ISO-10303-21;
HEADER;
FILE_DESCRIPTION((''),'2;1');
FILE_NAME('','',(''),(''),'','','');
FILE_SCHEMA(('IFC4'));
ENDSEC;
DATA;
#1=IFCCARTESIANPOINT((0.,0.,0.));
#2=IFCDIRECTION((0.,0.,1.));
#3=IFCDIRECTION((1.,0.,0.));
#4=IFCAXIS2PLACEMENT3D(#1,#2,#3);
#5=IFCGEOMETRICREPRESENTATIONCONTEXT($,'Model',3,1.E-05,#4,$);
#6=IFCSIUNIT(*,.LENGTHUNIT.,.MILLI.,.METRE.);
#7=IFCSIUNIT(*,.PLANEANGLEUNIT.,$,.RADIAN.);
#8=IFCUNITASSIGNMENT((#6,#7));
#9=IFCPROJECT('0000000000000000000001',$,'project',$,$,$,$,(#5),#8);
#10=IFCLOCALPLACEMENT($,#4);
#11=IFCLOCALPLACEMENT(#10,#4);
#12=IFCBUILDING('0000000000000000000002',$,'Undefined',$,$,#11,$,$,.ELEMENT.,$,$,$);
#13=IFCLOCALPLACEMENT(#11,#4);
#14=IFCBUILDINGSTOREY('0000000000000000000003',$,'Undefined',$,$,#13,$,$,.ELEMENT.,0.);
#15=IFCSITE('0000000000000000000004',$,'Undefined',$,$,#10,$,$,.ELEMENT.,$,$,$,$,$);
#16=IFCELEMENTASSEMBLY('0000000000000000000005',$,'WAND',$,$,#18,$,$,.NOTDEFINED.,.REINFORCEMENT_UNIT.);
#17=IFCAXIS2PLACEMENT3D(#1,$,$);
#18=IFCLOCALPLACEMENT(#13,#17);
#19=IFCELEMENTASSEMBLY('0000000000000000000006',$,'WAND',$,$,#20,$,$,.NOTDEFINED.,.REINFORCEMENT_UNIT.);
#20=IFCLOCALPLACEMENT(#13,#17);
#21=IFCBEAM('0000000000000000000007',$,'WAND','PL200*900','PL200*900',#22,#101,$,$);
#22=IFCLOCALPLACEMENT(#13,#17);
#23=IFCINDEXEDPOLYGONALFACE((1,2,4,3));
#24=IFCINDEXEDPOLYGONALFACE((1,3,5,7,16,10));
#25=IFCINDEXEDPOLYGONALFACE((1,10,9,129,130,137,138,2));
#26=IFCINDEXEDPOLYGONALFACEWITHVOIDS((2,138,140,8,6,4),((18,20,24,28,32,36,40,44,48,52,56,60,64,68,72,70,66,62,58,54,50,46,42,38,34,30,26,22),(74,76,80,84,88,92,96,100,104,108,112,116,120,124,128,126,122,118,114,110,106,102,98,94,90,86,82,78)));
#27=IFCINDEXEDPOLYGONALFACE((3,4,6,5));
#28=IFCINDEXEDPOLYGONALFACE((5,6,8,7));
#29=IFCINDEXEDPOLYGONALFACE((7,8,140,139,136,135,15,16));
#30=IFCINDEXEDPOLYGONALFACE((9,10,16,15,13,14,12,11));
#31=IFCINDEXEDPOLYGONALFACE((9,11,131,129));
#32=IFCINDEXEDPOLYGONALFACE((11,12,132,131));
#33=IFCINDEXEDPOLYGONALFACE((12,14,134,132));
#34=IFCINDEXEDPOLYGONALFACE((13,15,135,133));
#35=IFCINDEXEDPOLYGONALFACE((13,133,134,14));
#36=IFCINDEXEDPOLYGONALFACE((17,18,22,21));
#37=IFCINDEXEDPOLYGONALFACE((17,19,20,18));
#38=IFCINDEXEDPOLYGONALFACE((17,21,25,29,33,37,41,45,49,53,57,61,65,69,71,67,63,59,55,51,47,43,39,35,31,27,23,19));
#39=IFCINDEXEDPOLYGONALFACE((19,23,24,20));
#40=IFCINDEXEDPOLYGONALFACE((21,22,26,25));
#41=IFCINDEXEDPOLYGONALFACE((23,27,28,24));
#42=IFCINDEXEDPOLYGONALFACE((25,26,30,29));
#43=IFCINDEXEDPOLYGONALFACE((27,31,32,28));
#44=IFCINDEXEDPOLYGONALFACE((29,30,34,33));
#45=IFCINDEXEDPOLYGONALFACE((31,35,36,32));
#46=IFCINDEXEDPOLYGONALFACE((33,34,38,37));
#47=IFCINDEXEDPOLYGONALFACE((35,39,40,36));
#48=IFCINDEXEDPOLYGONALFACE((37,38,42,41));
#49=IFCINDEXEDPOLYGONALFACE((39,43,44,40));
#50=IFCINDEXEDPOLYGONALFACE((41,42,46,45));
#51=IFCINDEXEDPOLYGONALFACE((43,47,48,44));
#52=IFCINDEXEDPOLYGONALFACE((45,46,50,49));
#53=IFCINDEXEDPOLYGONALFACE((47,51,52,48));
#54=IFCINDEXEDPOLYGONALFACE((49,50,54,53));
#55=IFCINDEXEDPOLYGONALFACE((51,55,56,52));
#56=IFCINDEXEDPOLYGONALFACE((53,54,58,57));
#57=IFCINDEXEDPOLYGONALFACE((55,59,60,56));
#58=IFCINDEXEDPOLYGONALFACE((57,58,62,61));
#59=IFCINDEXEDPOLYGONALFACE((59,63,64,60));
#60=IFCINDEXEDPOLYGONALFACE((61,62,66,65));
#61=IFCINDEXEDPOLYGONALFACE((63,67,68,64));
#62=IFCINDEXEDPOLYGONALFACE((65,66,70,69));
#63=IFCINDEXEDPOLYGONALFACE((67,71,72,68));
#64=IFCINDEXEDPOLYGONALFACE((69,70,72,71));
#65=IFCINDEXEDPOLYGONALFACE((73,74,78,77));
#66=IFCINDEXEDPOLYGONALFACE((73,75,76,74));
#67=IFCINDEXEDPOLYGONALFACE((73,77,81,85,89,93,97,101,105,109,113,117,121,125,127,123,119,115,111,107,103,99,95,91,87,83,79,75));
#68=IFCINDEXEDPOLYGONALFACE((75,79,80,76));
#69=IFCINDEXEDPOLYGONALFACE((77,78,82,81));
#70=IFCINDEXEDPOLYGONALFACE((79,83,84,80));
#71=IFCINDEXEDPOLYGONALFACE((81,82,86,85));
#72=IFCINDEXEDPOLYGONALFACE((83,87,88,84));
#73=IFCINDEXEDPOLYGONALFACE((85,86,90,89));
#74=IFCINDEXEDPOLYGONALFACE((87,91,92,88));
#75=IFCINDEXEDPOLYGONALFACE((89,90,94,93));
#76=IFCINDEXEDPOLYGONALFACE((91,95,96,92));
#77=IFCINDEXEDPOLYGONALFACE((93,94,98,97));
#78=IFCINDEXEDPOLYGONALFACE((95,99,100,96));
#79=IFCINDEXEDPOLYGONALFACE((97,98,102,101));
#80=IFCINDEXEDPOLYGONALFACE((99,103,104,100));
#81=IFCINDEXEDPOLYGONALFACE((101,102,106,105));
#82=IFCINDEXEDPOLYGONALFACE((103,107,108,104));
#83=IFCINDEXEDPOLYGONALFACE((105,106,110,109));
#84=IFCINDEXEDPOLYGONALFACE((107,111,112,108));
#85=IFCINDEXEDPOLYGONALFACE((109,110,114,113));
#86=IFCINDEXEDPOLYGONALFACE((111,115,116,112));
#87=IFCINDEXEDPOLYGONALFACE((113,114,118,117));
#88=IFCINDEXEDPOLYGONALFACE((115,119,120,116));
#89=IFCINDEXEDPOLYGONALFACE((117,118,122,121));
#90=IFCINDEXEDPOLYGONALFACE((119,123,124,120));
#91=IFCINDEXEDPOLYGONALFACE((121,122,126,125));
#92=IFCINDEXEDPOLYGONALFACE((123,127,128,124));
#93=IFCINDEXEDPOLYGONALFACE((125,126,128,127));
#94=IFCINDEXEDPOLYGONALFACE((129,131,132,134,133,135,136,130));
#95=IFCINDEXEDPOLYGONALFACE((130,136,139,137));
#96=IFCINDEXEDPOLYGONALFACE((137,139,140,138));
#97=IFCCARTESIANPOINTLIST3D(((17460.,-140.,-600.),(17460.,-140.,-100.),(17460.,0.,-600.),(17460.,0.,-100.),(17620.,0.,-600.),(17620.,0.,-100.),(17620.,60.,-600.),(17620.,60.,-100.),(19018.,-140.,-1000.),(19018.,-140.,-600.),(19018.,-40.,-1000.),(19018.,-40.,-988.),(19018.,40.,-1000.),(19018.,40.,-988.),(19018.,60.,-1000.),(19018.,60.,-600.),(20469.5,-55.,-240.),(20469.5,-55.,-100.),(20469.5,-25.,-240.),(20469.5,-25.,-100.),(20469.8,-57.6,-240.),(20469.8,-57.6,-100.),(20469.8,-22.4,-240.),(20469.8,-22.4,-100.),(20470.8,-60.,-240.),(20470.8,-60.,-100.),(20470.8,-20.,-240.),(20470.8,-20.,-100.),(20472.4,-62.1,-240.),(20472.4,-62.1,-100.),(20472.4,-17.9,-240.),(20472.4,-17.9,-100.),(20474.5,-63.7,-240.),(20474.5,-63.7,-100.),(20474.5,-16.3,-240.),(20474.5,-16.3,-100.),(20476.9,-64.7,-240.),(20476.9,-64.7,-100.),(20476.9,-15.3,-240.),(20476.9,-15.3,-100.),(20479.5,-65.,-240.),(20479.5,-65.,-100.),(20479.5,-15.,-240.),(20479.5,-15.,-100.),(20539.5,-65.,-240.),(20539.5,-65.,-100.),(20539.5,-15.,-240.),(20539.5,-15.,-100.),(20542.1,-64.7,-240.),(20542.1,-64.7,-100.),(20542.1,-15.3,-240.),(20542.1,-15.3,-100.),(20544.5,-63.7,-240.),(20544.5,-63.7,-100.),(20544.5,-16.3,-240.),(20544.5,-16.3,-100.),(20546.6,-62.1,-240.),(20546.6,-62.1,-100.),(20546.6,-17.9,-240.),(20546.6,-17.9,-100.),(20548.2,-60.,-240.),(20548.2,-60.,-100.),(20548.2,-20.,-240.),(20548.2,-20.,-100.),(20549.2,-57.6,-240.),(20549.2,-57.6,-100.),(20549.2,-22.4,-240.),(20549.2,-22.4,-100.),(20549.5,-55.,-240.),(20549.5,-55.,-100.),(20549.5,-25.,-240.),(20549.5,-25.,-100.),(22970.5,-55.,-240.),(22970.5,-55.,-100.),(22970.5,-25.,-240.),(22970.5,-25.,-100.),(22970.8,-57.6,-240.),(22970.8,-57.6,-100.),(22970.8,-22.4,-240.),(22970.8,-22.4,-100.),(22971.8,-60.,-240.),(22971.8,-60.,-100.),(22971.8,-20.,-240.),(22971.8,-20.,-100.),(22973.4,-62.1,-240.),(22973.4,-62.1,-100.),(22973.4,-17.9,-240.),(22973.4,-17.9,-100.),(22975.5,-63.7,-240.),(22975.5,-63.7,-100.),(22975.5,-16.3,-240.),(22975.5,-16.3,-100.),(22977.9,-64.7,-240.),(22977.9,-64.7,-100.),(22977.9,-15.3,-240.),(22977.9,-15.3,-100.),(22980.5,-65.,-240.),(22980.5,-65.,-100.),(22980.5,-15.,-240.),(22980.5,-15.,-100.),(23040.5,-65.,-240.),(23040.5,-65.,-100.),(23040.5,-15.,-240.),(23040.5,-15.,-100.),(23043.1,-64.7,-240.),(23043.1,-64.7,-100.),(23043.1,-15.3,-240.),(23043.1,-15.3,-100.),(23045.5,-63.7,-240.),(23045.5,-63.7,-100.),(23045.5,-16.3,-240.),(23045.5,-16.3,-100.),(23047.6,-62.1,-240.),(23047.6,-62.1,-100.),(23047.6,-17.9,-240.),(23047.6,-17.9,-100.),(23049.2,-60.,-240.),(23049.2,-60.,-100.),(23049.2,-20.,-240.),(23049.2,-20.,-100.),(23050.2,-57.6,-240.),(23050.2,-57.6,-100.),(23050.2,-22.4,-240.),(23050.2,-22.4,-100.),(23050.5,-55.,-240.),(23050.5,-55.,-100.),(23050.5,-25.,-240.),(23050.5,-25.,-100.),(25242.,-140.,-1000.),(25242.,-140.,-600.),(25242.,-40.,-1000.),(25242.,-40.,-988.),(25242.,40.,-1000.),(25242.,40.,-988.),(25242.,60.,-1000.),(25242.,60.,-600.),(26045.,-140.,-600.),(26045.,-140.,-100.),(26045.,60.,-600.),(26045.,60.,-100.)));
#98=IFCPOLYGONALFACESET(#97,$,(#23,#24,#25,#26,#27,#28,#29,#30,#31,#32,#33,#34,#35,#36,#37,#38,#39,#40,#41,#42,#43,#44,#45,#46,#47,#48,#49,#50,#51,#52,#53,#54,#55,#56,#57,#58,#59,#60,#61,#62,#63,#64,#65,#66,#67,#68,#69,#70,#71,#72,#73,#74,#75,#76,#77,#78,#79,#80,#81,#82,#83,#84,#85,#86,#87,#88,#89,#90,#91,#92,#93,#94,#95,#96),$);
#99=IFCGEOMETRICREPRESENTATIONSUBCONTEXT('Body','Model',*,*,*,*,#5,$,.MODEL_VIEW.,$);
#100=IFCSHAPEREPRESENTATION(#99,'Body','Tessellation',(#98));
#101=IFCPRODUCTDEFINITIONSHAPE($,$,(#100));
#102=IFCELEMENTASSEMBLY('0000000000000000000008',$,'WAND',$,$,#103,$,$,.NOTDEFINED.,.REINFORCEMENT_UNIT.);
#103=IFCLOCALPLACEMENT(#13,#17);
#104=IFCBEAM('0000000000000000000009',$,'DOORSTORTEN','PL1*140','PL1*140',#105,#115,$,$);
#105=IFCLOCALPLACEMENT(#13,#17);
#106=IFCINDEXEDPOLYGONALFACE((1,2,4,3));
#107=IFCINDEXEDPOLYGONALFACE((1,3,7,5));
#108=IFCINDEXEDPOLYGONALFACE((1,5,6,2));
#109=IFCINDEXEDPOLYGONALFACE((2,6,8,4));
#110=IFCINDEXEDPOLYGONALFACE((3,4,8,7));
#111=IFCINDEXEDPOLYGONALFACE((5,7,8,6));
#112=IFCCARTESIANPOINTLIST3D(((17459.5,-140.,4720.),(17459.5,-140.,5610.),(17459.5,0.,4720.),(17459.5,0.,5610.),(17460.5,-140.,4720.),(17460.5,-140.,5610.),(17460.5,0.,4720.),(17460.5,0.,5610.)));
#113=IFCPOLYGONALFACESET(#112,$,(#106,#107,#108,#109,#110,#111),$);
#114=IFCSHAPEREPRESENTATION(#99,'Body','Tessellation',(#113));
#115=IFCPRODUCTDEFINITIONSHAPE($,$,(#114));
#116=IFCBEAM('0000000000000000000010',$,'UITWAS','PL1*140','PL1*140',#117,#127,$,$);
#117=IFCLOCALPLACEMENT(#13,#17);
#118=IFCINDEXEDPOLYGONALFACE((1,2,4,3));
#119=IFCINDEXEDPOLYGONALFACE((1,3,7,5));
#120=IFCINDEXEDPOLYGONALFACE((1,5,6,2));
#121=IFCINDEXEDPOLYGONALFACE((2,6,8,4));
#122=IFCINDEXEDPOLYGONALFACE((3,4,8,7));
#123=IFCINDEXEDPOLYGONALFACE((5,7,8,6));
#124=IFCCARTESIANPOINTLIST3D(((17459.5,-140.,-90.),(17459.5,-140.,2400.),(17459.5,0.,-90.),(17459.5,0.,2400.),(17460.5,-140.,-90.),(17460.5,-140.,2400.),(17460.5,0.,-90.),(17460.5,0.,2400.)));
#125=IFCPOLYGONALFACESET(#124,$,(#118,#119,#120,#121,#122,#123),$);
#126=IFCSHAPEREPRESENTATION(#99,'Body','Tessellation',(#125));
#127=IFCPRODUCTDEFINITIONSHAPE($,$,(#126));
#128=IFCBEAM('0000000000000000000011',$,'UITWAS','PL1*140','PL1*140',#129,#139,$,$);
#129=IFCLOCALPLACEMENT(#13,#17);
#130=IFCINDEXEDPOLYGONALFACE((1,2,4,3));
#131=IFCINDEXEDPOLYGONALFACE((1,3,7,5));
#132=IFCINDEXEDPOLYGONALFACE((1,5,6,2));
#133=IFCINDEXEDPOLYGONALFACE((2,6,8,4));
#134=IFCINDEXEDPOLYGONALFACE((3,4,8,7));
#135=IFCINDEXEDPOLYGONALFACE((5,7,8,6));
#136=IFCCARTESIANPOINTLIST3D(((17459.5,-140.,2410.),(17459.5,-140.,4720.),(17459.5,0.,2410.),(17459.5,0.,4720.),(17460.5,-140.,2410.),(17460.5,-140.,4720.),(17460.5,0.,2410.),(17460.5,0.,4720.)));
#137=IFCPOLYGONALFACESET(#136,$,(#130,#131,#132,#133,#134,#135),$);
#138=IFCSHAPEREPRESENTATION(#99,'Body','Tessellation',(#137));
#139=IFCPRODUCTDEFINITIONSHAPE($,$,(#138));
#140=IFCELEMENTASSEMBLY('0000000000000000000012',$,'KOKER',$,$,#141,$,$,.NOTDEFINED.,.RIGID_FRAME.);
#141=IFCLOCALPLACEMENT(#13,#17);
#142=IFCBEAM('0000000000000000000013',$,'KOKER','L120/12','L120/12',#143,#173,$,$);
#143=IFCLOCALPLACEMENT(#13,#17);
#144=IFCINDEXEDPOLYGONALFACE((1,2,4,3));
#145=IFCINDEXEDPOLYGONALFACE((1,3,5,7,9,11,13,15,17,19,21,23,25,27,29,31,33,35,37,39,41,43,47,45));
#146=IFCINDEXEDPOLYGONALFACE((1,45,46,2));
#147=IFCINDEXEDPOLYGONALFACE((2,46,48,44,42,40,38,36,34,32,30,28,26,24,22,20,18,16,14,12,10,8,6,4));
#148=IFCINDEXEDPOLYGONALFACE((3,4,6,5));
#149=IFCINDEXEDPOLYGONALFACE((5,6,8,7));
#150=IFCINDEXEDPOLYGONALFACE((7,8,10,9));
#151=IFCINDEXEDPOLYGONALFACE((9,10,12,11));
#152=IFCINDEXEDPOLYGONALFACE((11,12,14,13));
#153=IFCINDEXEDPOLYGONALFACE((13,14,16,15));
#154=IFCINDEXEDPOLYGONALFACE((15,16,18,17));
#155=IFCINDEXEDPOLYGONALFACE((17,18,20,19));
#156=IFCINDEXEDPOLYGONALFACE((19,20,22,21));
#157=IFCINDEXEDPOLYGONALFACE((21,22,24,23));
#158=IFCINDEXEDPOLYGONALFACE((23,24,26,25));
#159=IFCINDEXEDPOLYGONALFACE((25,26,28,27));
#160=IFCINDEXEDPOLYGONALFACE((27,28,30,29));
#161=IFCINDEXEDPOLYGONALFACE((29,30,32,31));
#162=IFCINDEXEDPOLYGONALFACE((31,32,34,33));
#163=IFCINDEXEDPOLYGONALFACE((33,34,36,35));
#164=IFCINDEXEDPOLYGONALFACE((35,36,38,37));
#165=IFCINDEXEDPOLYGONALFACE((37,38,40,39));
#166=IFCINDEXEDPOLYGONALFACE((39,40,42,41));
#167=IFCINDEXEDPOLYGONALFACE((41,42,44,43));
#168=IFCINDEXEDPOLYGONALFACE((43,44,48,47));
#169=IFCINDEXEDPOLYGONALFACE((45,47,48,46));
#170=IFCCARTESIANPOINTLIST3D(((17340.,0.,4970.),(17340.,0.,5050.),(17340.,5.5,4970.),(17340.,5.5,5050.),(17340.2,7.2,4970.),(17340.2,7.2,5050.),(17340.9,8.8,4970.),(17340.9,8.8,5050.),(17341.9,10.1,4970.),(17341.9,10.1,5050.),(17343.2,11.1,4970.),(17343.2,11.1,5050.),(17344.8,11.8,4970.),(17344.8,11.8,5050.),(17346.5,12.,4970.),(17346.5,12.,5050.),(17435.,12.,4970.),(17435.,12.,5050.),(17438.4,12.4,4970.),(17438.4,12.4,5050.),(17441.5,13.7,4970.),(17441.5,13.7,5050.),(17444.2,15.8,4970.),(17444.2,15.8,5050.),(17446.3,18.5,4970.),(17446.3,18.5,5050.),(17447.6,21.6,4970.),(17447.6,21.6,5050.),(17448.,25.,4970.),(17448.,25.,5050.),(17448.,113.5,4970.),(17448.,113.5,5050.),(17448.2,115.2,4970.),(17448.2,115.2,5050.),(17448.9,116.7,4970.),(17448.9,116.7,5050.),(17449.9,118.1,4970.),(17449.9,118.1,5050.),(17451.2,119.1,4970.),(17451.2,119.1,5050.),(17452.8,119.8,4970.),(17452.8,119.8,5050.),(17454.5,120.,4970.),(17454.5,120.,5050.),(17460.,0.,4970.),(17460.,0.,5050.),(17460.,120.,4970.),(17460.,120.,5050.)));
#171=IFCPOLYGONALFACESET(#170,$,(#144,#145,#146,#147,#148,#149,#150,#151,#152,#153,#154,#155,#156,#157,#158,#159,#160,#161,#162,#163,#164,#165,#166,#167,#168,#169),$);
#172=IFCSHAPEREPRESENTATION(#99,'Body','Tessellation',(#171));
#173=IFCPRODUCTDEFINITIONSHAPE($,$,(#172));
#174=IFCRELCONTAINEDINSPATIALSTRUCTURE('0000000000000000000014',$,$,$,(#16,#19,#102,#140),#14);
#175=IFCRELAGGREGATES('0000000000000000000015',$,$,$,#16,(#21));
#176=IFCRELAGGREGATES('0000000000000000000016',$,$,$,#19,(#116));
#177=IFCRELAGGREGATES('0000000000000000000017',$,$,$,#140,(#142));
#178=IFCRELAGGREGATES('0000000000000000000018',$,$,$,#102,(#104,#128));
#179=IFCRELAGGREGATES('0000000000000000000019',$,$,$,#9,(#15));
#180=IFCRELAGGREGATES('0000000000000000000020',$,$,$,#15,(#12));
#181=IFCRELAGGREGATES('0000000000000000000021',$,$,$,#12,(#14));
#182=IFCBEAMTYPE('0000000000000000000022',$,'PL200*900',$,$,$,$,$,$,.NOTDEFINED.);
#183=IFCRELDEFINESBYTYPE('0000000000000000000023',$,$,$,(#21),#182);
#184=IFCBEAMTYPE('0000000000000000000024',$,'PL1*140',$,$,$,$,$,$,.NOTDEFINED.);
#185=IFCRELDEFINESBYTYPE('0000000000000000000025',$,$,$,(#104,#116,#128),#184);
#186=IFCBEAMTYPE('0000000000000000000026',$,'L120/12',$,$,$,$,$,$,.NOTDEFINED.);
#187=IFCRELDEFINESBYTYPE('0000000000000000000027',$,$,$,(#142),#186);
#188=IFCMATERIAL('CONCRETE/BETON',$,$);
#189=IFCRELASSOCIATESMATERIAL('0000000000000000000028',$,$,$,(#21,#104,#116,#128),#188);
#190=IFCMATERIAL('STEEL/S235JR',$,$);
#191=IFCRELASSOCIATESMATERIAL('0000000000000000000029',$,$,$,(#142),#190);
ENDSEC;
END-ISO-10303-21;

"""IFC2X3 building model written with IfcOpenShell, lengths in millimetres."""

from ifc_helpers import new_model, si_unit, frame, frame_2d, origin_with_axes, place, context, subcontext, project, spatial, polyline, circle_curve, parameter, trimmed, segment, composite_curve, rectangle, l_section, outline, extrude, boolean, material, type_object, element, aggregate, save


model = new_model("IFC2X3")

# Units and contexts
model_context = context("Model", 3, precision=1e-05, world=origin_with_axes())
body_context = subcontext(model_context, "Body", "Model", "MODEL_VIEW")
ifc_project = project(units=[si_unit("LENGTHUNIT", "METRE", prefix="MILLI"), si_unit("PLANEANGLEUNIT", "RADIAN")], contexts=[model_context])

# Site, building, storey
site_placement = place(None, origin_with_axes())
site = spatial("IfcSite", under=ifc_project, at=site_placement, Name="Undefined", CompositionType="ELEMENT")
building_placement = place(site_placement, origin_with_axes())
building = spatial("IfcBuilding", under=site, at=building_placement, Name="Undefined", CompositionType="ELEMENT")
storey_placement = place(building_placement, origin_with_axes())
storey = spatial("IfcBuildingStorey", under=building, at=storey_placement, Name="Undefined", CompositionType="ELEMENT", Elevation=0.0)

# Element assembly
assembly_1_placement = place(storey_placement, origin_with_axes())
assembly_1 = element("IfcElementAssembly", 1, at=assembly_1_placement, inside=storey, Name="WAND", AssemblyPlace="NOTDEFINED", PredefinedType="REINFORCEMENT_UNIT")

# Element assembly
assembly_2_placement = place(storey_placement, origin_with_axes())
assembly_2 = element("IfcElementAssembly", 2, at=assembly_2_placement, inside=storey, Name="WAND", AssemblyPlace="NOTDEFINED", PredefinedType="REINFORCEMENT_UNIT")

# Beam
ifc_material_1 = material(Name="CONCRETE/BETON")
beam_type_1 = type_object("IfcBeamType", Name="PL200*900", PredefinedType="NOTDEFINED")
beam_1_placement = place(assembly_1_placement, frame((17460.0, -40.0, -550.0), z_axis=(0.0, 0.0, 1.0), x_axis=(1.0, 0.0, 0.0)))
beam_1 = element("IfcBeam", 3, at=beam_1_placement, type_object=beam_type_1, material=ifc_material_1, Name="WAND", Description="PL200*900", ObjectType="PL200*900", context=body_context, shape_type="CSG", body=[
    boolean("DIFFERENCE", boolean("DIFFERENCE", boolean("DIFFERENCE", boolean("DIFFERENCE", boolean("DIFFERENCE", boolean("DIFFERENCE", extrude(rectangle(XDim=200.0, YDim=900.0, at=frame_2d((0.0, 0.0), x_axis=(1.0, 0.0))), frame((8585.0, 0.0, 0.0), z_axis=(-1.0, 0.0, 0.0), x_axis=(0.0, -1.0, 0.0)), (0.0, 0.0, 1.0), 8585.0), extrude(outline(composite_curve([segment(trimmed(circle_curve(frame_2d((10.0, 10.0), x_axis=(-1.0, 0.0)), 10.0), [parameter(0.0)], [parameter(1.570796)], True, "PARAMETER"), True, "CONTINUOUS"), segment(polyline([(10.0, 0.0), (40.0, 0.0)]), True, "CONTINUOUS"), segment(trimmed(circle_curve(frame_2d((40.0, 10.0), x_axis=(0.0, -1.0)), 10.0), [parameter(0.0)], [parameter(1.570796)], True, "PARAMETER"), True, "CONTINUOUS"), segment(polyline([(50.0, 10.0), (50.0, 70.0)]), True, "CONTINUOUS"), segment(trimmed(circle_curve(frame_2d((40.0, 70.0), x_axis=(1.0, 0.0)), 10.0), [parameter(0.0)], [parameter(1.570796)], True, "PARAMETER"), True, "CONTINUOUS"), segment(polyline([(40.0, 80.0), (10.0, 80.0)]), True, "CONTINUOUS"), segment(trimmed(circle_curve(frame_2d((10.0, 70.0), x_axis=(0.0, 1.0)), 10.0), [parameter(0.0)], [parameter(1.570796)], True, "PARAMETER"), True, "CONTINUOUS"), segment(polyline([(0.0, 70.0), (0.0, 10.0)]), True, "CONTINUOUS")], self_intersect=True)), frame((3089.5, -25.0, 310.0), z_axis=(0.0, 0.0, 1.0), x_axis=(0.0, 1.0, 0.0)), (0.0, 0.0, 1.0), 150.0)), extrude(outline(composite_curve([segment(trimmed(circle_curve(frame_2d((10.0, 10.0), x_axis=(-1.0, 0.0)), 10.0), [parameter(0.0)], [parameter(1.570796)], True, "PARAMETER"), True, "CONTINUOUS"), segment(polyline([(10.0, 0.0), (40.0, 0.0)]), True, "CONTINUOUS"), segment(trimmed(circle_curve(frame_2d((40.0, 10.0), x_axis=(0.0, -1.0)), 10.0), [parameter(0.0)], [parameter(1.570796)], True, "PARAMETER"), True, "CONTINUOUS"), segment(polyline([(50.0, 10.0), (50.0, 70.0)]), True, "CONTINUOUS"), segment(trimmed(circle_curve(frame_2d((40.0, 70.0), x_axis=(1.0, 0.0)), 10.0), [parameter(0.0)], [parameter(1.570796)], True, "PARAMETER"), True, "CONTINUOUS"), segment(polyline([(40.0, 80.0), (10.0, 80.0)]), True, "CONTINUOUS"), segment(trimmed(circle_curve(frame_2d((10.0, 70.0), x_axis=(0.0, 1.0)), 10.0), [parameter(0.0)], [parameter(1.570796)], True, "PARAMETER"), True, "CONTINUOUS"), segment(polyline([(0.0, 70.0), (0.0, 10.0)]), True, "CONTINUOUS")], self_intersect=True)), frame((5510.5, 25.0, 310.0), z_axis=(0.0, 0.0, 1.0), x_axis=(0.0, -1.0, 0.0)), (0.0, 0.0, 1.0), 150.0)), extrude(rectangle(XDim=210.0, YDim=803.0, at=frame_2d((0.0, 0.0), x_axis=(1.0, 0.0))), frame((8183.5, 0.0, -50.0), z_axis=(0.0, 0.0, -1.0), x_axis=(0.0, -1.0, 0.0)), (0.0, 0.0, 1.0), 1000.0)), extrude(rectangle(XDim=210.0, YDim=1558.0, at=frame_2d((0.0, 0.0), x_axis=(1.0, 0.0))), frame((779.0, 0.0, -50.0), z_axis=(0.0, 0.0, -1.0), x_axis=(0.0, -1.0, 0.0)), (0.0, 0.0, 1.0), 1000.0)), extrude(outline(polyline([(0.0, 0.0), (60.0, 0.0), (60.0, 185.3), (0.0, 185.3), (0.0, 0.0)])), frame((160.0, 100.0, 2552.5), z_axis=(0.0, 0.0, -1.0), x_axis=(0.0, -1.0, 0.0)), (0.0, 0.0, 1.0), 3005.0)), extrude(rectangle(XDim=12.0, YDim=80.0, at=frame_2d((0.0, 0.0), x_axis=(1.0, 0.0))), frame((8585.0, 40.0, -444.0), z_axis=(-1.0, 0.0, 0.0), x_axis=(0.0, 0.0, -1.0)), (0.0, 0.0, 1.0), 8585.0)),
])
aggregate(assembly_1, [beam_1])

# Element assembly, beam
assembly_3_placement = place(storey_placement, origin_with_axes())
assembly_3 = element("IfcElementAssembly", 4, at=assembly_3_placement, inside=storey, Name="WAND", AssemblyPlace="NOTDEFINED", PredefinedType="REINFORCEMENT_UNIT")
beam_type_2 = type_object("IfcBeamType", Name="PL1*140", PredefinedType="NOTDEFINED")
beam_2_placement = place(assembly_3_placement, frame((17460.0, -70.0, 5610.0), z_axis=(0.0, -1.0, 0.0), x_axis=(0.0, 0.0, -1.0)))
beam_2 = element("IfcBeam", 5, at=beam_2_placement, type_object=beam_type_2, material=ifc_material_1, Name="DOORSTORTEN", Description="PL1*140", ObjectType="PL1*140", context=body_context, shape_type="SweptSolid", body=[
    extrude(rectangle(XDim=1.0, YDim=140.0, at=frame_2d((0.0, 0.0), x_axis=(1.0, 0.0))), frame((890.0, 0.0, 0.0), z_axis=(-1.0, 0.0, 0.0), x_axis=(0.0, -1.0, 0.0)), (0.0, 0.0, 1.0), 890.0),
])

# Beams
beam_3_placement = place(assembly_2_placement, frame((17460.0, -70.0, -90.0), z_axis=(0.0, -1.0, 0.0), x_axis=(0.0, 0.0, 1.0)))
beam_3 = element("IfcBeam", 6, at=beam_3_placement, type_object=beam_type_2, material=ifc_material_1, Name="UITWAS", Description="PL1*140", ObjectType="PL1*140", context=body_context, shape_type="SweptSolid", body=[
    extrude(rectangle(XDim=1.0, YDim=140.0, at=frame_2d((0.0, 0.0), x_axis=(1.0, 0.0))), frame((2490.0, 0.0, 0.0), z_axis=(-1.0, 0.0, 0.0), x_axis=(0.0, -1.0, 0.0)), (0.0, 0.0, 1.0), 2490.0),
])
aggregate(assembly_2, [beam_3])
beam_4_placement = place(assembly_3_placement, frame((17460.0, -70.0, 2410.0), z_axis=(0.0, -1.0, 0.0), x_axis=(0.0, 0.0, 1.0)))
beam_4 = element("IfcBeam", 7, at=beam_4_placement, type_object=beam_type_2, material=ifc_material_1, Name="UITWAS", Description="PL1*140", ObjectType="PL1*140", context=body_context, shape_type="SweptSolid", body=[
    extrude(rectangle(XDim=1.0, YDim=140.0, at=frame_2d((0.0, 0.0), x_axis=(1.0, 0.0))), frame((2310.0, 0.0, 0.0), z_axis=(-1.0, 0.0, 0.0), x_axis=(0.0, -1.0, 0.0)), (0.0, 0.0, 1.0), 2310.0),
])

# Element assembly, beam
assembly_4_placement = place(storey_placement, origin_with_axes())
assembly_4 = element("IfcElementAssembly", 8, at=assembly_4_placement, inside=storey, Name="KOKER", AssemblyPlace="NOTDEFINED", PredefinedType="RIGID_FRAME")
ifc_material_2 = material(Name="STEEL/S235JR")
beam_type_3 = type_object("IfcBeamType", Name="L120/12", PredefinedType="NOTDEFINED")
beam_5_placement = place(assembly_4_placement, frame((17400.0, 60.0, 5050.0), z_axis=(-1.0, 0.0, 0.0), x_axis=(0.0, 0.0, -1.0)))
beam_5 = element("IfcBeam", 9, at=beam_5_placement, type_object=beam_type_3, material=ifc_material_2, Name="KOKER", Description="L120/12", ObjectType="L120/12", context=body_context, shape_type="SweptSolid", body=[
    extrude(l_section(Depth=120.0, Width=120.0, Thickness=12.0, FilletRadius=13.0, EdgeRadius=6.5, at=frame_2d((0.0, 0.0), x_axis=(1.0, 0.0))), frame((80.0, 0.0, 0.0), z_axis=(-1.0, 0.0, 0.0), x_axis=(0.0, -1.0, 0.0)), (0.0, 0.0, 1.0), 80.0),
])
aggregate(assembly_4, [beam_5])

aggregate(assembly_3, [beam_2, beam_4])

save(model, "model.ifc")
